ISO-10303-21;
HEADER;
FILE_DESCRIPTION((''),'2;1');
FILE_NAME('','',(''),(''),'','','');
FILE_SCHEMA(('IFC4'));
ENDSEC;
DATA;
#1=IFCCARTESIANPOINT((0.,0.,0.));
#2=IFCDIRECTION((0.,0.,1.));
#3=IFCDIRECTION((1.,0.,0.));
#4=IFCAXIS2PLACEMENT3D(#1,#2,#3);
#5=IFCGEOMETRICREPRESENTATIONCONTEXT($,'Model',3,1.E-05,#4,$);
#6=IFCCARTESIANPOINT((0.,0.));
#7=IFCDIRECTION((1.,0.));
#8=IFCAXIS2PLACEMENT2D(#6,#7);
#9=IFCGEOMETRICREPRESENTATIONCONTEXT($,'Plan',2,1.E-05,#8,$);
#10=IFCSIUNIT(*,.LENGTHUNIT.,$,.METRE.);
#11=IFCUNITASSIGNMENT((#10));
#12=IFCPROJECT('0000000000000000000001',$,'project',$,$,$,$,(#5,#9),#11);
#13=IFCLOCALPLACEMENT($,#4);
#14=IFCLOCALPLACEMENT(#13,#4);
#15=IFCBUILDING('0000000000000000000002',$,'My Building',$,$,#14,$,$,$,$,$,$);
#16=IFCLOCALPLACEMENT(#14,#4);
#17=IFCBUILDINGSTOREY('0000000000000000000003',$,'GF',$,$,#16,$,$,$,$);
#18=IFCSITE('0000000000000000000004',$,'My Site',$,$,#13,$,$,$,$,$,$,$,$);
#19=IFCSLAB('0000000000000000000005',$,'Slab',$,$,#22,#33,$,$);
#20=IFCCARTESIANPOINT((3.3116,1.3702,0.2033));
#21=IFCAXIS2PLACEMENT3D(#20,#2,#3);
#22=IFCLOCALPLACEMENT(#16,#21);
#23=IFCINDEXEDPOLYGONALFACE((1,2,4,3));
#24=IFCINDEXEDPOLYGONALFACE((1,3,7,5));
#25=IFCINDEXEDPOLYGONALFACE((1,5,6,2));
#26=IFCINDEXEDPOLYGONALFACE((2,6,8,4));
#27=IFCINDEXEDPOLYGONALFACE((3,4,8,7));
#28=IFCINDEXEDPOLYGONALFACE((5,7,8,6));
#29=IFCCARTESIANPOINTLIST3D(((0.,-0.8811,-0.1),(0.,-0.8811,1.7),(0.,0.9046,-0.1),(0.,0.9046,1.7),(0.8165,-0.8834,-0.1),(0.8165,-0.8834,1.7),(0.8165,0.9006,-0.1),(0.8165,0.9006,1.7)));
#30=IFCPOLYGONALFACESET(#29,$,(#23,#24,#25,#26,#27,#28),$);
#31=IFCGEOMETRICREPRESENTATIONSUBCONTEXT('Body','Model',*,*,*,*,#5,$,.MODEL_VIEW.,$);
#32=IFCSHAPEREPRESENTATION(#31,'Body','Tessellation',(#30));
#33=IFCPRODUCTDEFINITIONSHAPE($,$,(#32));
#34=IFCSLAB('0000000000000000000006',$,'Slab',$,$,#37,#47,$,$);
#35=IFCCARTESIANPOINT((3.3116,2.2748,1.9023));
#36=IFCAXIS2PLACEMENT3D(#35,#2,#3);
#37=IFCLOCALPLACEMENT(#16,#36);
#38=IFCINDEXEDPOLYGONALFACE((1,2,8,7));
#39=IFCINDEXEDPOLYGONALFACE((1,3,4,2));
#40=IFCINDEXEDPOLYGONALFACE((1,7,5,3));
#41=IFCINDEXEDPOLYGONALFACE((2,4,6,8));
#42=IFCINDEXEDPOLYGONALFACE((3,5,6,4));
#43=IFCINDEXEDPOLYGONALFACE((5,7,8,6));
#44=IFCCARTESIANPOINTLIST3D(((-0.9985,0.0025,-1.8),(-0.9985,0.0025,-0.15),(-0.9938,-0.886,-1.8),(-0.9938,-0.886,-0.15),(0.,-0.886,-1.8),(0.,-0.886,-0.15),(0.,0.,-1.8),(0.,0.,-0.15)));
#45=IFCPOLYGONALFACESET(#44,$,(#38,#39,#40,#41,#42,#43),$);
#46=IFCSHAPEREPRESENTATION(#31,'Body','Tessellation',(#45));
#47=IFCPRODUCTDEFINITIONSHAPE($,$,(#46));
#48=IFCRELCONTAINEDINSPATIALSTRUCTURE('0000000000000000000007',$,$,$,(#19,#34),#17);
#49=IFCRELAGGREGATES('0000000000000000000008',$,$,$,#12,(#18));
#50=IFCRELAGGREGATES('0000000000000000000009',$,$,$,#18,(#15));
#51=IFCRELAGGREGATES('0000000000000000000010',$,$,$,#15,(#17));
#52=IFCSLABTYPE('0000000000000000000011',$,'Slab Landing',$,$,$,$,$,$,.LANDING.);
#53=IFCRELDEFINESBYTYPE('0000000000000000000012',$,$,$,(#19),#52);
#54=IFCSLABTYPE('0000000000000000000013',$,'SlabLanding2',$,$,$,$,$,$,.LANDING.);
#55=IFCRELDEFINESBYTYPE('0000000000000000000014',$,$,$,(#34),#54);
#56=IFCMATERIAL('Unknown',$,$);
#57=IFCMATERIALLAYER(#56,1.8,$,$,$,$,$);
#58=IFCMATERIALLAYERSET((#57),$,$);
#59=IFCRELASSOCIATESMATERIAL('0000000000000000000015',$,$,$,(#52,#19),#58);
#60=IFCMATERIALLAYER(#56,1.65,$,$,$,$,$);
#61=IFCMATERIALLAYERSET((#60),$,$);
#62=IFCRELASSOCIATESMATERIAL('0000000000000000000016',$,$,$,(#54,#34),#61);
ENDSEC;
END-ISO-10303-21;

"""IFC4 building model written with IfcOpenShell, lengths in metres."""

from ifc_helpers import new_model, si_unit, frame, origin_with_axes, origin_2d_with_axis, place, context, subcontext, project, spatial, indexed_curve, outline, extrude, material, layer, layer_set, layer_usage, type_object, element, save


model = new_model("IFC4")

# Units and contexts
model_context = context("Model", 3, precision=1e-05, world=origin_with_axes())
plan_context = context("Plan", 2, precision=1e-05, world=origin_2d_with_axis())
body_context_1 = subcontext(model_context, "Body", "Model", "MODEL_VIEW")
ifc_project = project(units=[si_unit("LENGTHUNIT", "METRE")], contexts=[model_context, plan_context])

# Site, building, storey
site_placement = place(None, origin_with_axes())
site = spatial("IfcSite", under=ifc_project, at=site_placement, Name="My Site")
building_placement = place(site_placement, origin_with_axes())
building = spatial("IfcBuilding", under=site, at=building_placement, Name="My Building")
storey_placement = place(building_placement, origin_with_axes())
storey = spatial("IfcBuildingStorey", under=building, at=storey_placement, Name="GF")

# Shared definitions
ifc_material = material(Name="Unknown")

# Slabs
ifc_layer_1 = layer(ifc_material, 1.8)
ifc_layer_set_1 = layer_set([ifc_layer_1])
ifc_layer_usage_1 = layer_usage(ifc_layer_set_1, "AXIS3", "POSITIVE", -0.1)
slab_type_1 = type_object("IfcSlabType", Name="Slab Landing", PredefinedType="LANDING", material=ifc_layer_set_1)
slab_1_placement = place(storey_placement, frame((3.3116, 1.3702, 0.2033), z_axis=(0.0, 0.0, 1.0), x_axis=(1.0, 0.0, 0.0)))
element("IfcSlab", 1, at=slab_1_placement, inside=storey, type_object=slab_type_1, material=ifc_layer_usage_1, Name="Slab", context=body_context_1, shape_type="SweptSolid", body=[
    extrude(outline(indexed_curve([(0.0, -0.8811), (0.8165, -0.8834), (0.8165, 0.9006), (0.0, 0.9046), (0.0, -0.8811)])), frame((0.0, 0.0, -0.1), z_axis=(0.0, 0.0, 1.0), x_axis=(1.0, 0.0, 0.0)), (0.0, 0.0, 1.0), 1.8),
])
ifc_layer_2 = layer(ifc_material, 1.65)
ifc_layer_set_2 = layer_set([ifc_layer_2])
ifc_layer_usage_2 = layer_usage(ifc_layer_set_2, "AXIS3", "POSITIVE", -1.8)
slab_type_2 = type_object("IfcSlabType", Name="SlabLanding2", PredefinedType="LANDING", material=ifc_layer_set_2)
slab_2_placement = place(storey_placement, frame((3.3116, 2.2748, 1.9023), z_axis=(0.0, 0.0, 1.0), x_axis=(1.0, 0.0, 0.0)))
element("IfcSlab", 2, at=slab_2_placement, inside=storey, type_object=slab_type_2, material=ifc_layer_usage_2, Name="Slab", context=body_context_1, shape_type="SweptSolid", body=[
    extrude(outline(indexed_curve([(0.0, 0.0), (0.0, -0.886), (-0.9938, -0.886), (-0.9985, 0.0025), (0.0, 0.0)])), frame((0.0, 0.0, -1.8), z_axis=(0.0, 0.0, 1.0), x_axis=(1.0, 0.0, 0.0)), (0.0, 0.0, 1.0), 1.65),
])

save(model, "model.ifc")
